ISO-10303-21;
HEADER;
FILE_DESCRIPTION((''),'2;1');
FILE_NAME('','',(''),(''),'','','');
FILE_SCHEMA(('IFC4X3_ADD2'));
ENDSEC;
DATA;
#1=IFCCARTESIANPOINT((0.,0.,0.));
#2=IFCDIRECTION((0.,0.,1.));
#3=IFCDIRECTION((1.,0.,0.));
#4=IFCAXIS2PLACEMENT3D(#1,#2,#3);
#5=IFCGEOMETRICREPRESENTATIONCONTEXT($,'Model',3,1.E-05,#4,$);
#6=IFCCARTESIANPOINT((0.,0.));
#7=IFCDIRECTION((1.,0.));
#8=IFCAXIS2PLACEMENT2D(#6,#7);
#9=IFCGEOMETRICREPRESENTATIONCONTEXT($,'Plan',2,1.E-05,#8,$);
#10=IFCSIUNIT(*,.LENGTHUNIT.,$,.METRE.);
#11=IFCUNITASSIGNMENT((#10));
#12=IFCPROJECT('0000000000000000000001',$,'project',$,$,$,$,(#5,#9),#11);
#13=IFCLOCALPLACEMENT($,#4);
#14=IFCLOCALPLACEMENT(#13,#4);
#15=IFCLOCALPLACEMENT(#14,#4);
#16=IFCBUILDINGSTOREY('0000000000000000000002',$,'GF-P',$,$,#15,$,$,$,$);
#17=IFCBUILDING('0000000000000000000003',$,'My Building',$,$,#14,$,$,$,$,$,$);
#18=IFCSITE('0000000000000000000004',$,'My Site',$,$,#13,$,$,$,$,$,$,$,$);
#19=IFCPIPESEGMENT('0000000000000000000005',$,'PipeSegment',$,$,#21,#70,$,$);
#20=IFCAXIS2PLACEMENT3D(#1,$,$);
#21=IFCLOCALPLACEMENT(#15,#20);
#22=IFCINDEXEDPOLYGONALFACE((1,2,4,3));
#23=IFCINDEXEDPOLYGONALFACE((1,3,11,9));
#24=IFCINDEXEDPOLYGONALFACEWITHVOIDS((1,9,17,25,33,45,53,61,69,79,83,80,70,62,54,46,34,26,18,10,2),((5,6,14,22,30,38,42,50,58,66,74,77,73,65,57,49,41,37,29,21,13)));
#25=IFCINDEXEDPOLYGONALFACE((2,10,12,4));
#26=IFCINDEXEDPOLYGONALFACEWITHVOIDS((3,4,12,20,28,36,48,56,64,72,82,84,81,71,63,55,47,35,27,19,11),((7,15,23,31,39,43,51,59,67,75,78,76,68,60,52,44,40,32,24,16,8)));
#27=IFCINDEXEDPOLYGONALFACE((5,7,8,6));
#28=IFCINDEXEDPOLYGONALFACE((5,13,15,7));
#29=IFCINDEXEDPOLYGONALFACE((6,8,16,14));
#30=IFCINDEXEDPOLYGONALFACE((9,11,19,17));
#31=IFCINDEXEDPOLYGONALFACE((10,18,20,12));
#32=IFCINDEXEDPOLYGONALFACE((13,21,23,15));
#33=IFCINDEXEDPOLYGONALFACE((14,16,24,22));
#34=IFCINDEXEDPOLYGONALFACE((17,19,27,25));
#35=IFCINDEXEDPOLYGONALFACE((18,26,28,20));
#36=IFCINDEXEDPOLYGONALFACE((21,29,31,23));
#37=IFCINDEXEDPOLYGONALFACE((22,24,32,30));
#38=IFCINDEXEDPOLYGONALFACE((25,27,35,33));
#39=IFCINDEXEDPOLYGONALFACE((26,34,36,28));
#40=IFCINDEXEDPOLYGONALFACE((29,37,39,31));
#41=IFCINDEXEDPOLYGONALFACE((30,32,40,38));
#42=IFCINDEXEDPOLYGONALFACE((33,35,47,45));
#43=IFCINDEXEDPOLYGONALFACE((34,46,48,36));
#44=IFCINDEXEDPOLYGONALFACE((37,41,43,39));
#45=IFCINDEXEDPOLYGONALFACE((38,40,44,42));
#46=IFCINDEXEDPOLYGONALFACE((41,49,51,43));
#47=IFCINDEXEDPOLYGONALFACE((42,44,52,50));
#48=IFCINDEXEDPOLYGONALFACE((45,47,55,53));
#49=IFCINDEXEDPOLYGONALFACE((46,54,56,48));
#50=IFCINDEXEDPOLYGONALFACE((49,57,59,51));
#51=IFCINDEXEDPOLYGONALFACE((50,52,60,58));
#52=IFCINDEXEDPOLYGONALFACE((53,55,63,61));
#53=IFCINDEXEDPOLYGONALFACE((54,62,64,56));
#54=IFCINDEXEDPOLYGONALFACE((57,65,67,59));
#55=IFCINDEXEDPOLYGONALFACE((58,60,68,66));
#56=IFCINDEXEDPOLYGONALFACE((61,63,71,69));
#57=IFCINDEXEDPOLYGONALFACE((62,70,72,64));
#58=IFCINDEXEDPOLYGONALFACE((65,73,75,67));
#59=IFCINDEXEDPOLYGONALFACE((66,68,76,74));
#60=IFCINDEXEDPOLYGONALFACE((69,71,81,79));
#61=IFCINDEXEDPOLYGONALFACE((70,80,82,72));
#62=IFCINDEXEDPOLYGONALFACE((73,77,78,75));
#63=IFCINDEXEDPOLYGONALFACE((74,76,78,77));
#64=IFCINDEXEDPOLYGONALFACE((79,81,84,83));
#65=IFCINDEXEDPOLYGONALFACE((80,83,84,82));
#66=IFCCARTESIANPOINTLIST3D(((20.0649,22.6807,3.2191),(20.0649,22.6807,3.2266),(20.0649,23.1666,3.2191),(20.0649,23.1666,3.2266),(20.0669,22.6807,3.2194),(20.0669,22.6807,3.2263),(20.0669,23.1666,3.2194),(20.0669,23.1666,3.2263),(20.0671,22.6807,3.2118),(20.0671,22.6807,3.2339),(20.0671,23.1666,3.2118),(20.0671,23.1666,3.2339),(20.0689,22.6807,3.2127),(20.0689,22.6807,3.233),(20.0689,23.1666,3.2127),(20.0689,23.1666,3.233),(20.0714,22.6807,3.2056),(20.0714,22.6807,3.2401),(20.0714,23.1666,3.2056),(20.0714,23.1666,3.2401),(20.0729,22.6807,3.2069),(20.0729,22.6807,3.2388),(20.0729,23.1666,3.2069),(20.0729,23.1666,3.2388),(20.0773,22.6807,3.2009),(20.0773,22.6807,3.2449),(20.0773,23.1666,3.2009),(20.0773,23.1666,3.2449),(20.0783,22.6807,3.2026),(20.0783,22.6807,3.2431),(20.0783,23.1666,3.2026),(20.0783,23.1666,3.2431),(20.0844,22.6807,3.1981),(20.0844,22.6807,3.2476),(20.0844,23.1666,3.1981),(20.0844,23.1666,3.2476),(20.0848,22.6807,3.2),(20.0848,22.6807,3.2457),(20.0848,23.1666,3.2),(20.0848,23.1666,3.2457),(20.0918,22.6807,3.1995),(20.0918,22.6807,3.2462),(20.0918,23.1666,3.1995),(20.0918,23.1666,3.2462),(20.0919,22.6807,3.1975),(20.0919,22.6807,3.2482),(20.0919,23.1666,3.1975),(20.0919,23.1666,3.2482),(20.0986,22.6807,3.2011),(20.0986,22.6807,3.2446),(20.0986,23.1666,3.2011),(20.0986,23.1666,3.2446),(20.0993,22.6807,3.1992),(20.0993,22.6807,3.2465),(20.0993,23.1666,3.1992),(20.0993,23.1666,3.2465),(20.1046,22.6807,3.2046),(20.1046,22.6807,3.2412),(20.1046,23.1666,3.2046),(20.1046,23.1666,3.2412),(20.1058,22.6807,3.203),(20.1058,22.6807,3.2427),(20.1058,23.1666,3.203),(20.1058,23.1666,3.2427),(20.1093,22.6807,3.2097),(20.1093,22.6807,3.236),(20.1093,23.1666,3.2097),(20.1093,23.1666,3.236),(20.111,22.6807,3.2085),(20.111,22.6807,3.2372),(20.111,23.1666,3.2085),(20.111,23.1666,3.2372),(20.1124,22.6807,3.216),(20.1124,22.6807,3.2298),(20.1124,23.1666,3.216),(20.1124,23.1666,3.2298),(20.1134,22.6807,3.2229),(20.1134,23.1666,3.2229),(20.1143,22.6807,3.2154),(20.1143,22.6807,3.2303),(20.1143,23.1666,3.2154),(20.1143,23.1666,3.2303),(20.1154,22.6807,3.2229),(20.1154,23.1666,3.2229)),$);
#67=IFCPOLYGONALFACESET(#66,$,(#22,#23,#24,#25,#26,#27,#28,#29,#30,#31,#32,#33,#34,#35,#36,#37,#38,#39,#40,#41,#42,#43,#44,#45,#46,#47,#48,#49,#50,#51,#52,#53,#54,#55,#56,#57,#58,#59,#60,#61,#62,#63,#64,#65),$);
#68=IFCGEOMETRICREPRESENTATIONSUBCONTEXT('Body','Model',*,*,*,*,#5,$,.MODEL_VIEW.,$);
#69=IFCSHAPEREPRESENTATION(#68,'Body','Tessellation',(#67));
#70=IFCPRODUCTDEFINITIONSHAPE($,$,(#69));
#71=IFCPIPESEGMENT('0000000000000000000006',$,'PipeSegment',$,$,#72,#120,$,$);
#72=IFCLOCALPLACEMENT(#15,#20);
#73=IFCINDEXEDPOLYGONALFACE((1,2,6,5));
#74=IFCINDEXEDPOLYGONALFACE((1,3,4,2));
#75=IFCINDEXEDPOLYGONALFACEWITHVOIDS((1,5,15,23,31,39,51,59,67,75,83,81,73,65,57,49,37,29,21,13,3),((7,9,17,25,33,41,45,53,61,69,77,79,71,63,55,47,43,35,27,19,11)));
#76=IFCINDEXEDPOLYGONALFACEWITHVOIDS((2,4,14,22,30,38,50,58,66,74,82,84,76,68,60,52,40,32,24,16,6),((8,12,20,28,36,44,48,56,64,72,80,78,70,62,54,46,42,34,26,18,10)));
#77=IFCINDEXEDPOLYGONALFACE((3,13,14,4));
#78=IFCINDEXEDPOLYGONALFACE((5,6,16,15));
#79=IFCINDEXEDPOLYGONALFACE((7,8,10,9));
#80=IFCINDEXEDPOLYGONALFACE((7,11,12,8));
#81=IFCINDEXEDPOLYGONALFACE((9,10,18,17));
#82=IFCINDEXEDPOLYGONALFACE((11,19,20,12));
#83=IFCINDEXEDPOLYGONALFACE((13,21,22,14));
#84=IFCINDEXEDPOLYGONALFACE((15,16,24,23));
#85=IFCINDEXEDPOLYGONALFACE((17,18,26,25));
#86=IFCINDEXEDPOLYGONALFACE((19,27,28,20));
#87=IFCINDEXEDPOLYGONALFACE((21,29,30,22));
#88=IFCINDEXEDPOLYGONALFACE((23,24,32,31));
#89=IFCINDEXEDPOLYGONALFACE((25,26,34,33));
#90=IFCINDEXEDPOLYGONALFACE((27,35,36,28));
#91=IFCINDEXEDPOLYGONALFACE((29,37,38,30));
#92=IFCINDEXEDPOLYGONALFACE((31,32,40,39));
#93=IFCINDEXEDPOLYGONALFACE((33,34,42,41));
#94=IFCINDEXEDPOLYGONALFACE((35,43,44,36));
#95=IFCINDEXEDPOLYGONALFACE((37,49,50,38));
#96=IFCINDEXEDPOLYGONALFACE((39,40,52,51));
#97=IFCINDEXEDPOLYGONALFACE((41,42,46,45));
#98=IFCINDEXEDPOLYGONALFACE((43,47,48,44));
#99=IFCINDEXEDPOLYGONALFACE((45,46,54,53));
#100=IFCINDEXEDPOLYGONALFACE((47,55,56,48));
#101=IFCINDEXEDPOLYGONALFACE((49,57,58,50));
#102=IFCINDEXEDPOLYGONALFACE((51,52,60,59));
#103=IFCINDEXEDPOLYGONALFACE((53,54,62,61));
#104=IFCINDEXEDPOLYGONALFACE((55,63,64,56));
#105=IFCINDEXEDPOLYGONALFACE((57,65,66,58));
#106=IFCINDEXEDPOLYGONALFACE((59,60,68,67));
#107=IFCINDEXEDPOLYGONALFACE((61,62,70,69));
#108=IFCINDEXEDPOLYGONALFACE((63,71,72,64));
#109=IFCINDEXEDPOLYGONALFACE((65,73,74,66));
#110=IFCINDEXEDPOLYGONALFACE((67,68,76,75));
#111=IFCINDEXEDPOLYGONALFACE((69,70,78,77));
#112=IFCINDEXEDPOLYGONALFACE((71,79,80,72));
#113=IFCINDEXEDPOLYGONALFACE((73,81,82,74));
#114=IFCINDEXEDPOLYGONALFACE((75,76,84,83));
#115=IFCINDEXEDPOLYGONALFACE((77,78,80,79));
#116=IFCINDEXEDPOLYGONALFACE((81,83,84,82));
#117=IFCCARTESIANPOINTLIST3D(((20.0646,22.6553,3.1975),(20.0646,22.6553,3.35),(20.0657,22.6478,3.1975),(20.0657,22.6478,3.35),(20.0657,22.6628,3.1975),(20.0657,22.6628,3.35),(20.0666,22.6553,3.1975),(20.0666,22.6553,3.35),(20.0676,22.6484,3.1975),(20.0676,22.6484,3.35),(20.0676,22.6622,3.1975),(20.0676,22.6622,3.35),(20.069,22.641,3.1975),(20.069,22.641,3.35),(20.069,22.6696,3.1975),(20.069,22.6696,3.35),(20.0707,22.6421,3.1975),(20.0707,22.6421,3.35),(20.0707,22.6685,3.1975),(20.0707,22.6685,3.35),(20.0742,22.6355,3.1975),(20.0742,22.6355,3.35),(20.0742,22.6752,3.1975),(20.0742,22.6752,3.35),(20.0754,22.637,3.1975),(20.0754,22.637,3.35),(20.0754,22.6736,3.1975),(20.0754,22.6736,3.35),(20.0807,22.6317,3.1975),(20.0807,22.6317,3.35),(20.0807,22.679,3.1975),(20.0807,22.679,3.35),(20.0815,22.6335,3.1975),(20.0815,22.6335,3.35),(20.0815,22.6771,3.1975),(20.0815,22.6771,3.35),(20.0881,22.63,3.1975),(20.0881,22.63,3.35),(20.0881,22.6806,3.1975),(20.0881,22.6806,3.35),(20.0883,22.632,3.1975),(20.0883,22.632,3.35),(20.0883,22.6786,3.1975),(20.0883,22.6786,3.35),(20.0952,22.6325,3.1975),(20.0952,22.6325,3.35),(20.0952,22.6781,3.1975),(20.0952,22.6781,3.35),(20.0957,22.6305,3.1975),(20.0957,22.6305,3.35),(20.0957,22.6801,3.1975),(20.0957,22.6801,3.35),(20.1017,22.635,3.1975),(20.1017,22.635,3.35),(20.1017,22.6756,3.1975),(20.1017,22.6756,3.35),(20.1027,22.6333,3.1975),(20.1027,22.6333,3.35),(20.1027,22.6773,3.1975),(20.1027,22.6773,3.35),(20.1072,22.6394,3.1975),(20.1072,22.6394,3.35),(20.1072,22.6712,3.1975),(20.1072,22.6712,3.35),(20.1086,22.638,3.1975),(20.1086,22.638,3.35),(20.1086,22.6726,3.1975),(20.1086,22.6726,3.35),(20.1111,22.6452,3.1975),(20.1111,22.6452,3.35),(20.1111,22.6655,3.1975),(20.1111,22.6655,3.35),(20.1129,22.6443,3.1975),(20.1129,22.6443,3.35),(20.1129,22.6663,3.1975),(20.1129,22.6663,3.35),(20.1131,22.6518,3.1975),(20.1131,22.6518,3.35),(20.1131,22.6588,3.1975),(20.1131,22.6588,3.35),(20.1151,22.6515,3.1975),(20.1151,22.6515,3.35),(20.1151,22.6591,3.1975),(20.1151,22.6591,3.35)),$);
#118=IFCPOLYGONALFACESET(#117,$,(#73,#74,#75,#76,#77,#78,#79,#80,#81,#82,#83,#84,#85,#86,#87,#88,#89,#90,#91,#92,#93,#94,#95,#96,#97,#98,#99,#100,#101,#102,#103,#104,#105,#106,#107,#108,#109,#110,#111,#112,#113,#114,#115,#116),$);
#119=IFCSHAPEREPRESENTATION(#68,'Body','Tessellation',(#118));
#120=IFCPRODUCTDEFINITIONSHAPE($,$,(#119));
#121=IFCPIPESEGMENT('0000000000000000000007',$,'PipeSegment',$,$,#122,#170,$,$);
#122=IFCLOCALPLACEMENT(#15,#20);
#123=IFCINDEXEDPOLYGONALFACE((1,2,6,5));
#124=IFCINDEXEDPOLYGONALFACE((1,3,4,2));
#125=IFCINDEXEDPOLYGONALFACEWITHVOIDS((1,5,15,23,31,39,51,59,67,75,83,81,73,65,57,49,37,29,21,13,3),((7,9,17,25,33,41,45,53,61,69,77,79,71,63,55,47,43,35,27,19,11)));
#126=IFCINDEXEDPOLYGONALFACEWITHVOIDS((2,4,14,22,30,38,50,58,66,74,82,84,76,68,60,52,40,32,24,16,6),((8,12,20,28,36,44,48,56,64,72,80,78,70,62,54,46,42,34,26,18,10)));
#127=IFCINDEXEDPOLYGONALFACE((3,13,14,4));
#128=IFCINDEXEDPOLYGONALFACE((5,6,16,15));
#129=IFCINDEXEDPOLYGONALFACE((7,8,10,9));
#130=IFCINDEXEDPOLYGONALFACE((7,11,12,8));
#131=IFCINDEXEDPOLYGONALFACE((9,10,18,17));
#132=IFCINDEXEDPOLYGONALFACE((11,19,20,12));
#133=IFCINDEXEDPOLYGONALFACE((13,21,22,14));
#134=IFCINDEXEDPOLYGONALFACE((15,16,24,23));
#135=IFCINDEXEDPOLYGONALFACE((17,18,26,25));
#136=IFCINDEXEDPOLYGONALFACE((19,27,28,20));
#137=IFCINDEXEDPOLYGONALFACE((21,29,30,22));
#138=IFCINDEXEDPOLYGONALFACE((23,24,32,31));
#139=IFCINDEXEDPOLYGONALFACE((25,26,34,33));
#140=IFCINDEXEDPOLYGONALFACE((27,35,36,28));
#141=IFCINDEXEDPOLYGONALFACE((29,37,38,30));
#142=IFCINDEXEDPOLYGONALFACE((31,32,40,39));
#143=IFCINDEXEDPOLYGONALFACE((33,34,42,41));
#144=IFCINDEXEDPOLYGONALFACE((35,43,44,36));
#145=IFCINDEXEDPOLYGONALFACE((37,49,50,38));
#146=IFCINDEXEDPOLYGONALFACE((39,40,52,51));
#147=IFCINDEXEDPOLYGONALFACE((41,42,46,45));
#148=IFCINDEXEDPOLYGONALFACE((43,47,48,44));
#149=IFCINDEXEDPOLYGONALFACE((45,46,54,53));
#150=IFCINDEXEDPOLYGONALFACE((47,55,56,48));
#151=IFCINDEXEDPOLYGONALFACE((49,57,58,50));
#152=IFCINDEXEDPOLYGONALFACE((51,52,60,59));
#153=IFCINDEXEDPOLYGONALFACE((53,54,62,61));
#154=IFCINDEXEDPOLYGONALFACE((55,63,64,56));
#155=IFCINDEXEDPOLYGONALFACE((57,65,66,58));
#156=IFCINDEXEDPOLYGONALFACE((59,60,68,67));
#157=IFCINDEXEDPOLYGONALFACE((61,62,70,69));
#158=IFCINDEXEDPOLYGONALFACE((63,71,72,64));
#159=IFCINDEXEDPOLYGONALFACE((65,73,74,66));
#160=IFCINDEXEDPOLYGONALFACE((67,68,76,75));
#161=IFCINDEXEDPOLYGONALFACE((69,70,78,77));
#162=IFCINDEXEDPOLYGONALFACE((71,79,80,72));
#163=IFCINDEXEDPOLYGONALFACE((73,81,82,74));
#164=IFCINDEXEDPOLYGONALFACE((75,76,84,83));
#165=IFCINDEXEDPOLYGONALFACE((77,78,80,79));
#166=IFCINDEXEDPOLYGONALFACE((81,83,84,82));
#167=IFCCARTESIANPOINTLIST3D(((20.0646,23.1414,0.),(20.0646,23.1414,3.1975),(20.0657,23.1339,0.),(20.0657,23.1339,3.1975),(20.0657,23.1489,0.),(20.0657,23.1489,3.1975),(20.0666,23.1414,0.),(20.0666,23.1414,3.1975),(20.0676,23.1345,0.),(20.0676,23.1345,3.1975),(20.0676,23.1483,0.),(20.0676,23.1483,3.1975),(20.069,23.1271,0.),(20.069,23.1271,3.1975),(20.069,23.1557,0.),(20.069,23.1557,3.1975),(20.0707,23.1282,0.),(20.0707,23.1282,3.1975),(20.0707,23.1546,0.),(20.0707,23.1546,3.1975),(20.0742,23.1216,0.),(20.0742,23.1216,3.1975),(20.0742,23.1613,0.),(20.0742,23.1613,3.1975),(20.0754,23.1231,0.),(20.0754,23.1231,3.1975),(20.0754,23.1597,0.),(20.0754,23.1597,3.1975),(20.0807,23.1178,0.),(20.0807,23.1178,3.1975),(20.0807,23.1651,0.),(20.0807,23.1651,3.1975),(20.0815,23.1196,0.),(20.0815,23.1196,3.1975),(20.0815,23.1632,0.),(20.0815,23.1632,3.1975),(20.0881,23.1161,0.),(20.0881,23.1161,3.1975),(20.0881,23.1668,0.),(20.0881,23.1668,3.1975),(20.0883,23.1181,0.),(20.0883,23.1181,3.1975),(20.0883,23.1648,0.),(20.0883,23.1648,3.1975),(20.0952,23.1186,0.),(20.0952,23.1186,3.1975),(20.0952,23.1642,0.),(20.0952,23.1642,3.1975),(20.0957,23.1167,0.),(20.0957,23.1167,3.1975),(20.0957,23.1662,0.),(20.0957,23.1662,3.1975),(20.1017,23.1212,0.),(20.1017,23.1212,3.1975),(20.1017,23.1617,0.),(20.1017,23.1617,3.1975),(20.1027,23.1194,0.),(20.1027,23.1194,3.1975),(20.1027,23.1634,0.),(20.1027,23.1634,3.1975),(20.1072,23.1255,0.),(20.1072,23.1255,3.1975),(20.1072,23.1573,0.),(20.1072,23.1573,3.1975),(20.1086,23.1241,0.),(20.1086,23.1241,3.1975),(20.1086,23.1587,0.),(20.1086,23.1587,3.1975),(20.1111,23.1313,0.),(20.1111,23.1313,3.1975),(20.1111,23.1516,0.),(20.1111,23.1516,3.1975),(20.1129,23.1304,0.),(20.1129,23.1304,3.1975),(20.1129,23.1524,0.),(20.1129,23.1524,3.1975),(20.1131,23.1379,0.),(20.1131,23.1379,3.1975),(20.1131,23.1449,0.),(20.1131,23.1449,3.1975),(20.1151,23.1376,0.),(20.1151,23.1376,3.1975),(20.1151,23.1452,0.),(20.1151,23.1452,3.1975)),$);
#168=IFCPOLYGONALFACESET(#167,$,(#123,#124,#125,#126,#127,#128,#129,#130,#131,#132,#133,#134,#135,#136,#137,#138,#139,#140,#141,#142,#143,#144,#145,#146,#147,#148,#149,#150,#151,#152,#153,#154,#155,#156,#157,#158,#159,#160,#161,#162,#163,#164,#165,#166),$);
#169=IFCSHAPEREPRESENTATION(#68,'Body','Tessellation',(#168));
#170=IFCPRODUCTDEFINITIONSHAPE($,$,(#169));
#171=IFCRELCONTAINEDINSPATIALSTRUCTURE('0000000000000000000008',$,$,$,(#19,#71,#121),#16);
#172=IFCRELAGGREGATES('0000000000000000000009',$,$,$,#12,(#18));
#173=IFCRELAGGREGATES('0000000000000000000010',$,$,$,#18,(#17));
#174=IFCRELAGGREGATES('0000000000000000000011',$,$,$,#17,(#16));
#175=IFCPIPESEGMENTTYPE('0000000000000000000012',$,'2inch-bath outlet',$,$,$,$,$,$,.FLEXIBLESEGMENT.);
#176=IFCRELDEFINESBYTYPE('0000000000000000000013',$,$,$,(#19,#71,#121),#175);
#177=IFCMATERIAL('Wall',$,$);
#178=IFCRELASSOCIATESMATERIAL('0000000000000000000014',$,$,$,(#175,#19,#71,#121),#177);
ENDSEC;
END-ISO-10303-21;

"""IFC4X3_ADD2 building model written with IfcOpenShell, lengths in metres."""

from ifc_helpers import new_model, si_unit, frame, origin_with_axes, origin_2d_with_axis, place, context, subcontext, project, spatial, hollow_circle, extrude, material, material_profile, profile_set, profile_usage, type_object, element, save


model = new_model("IFC4X3_ADD2")

# Units and contexts
model_context = context("Model", 3, precision=1e-05, world=origin_with_axes())
plan_context = context("Plan", 2, precision=1e-05, world=origin_2d_with_axis())
body_context = subcontext(model_context, "Body", "Model", "MODEL_VIEW")
ifc_project = project(units=[si_unit("LENGTHUNIT", "METRE")], contexts=[model_context, plan_context])

# Site, building, storey
site_placement = place(None, origin_with_axes())
site = spatial("IfcSite", under=ifc_project, at=site_placement, Name="My Site")
building_placement = place(site_placement, origin_with_axes())
building = spatial("IfcBuilding", under=site, at=building_placement, Name="My Building")
storey_placement = place(building_placement, origin_with_axes())
storey = spatial("IfcBuildingStorey", under=building, at=storey_placement, Name="GF-P")

# Pipe segments
ifc_material_1 = material(Name="Wall")
ifc_material_profile_1 = material_profile(ifc_material_1, hollow_circle(Radius=0.0254, WallThickness=0.002))
ifc_profile_set_1 = profile_set([ifc_material_profile_1], Name="graywater")
pipe_segment_type_1 = type_object("IfcPipeSegmentType", Name="2inch-bath outlet", PredefinedType="FLEXIBLESEGMENT", material=ifc_profile_set_1)
ifc_profile_usage_1 = profile_usage(ifc_profile_set_1)
pipe_segment_1_placement = place(storey_placement, frame((20.09, 23.1666, 3.2229), z_axis=(0.0, -1.0, 0.0), x_axis=(1.0, 0.0, 0.0)))
element("IfcPipeSegment", 1, at=pipe_segment_1_placement, inside=storey, type_object=pipe_segment_type_1, material=ifc_profile_usage_1, Name="PipeSegment", context=body_context, shape_type="SweptSolid", body=[
    extrude(hollow_circle(Radius=0.0254, WallThickness=0.002), origin_with_axes(), (0.0, 0.0, 1.0), 0.4859),
])
ifc_profile_usage_2 = profile_usage(ifc_profile_set_1)
pipe_segment_2_placement = place(storey_placement, frame((20.09, 22.6553, 3.1975), z_axis=(0.0, 0.0, 1.0), x_axis=(-1.0, 0.0, 0.0)))
element("IfcPipeSegment", 2, at=pipe_segment_2_placement, inside=storey, type_object=pipe_segment_type_1, material=ifc_profile_usage_2, Name="PipeSegment", context=body_context, shape_type="SweptSolid", body=[
    extrude(hollow_circle(Radius=0.0254, WallThickness=0.002), origin_with_axes(), (0.0, 0.0, 1.0), 0.1525),
])
ifc_profile_usage_3 = profile_usage(ifc_profile_set_1)
pipe_segment_3_placement = place(storey_placement, frame((20.09, 23.1414, 0.0), z_axis=(0.0, 0.0, 1.0), x_axis=(-1.0, 0.0, 0.0)))
element("IfcPipeSegment", 3, at=pipe_segment_3_placement, inside=storey, type_object=pipe_segment_type_1, material=ifc_profile_usage_3, Name="PipeSegment", context=body_context, shape_type="SweptSolid", body=[
    extrude(hollow_circle(Radius=0.0254, WallThickness=0.002), origin_with_axes(), (0.0, 0.0, 1.0), 3.1975),
])

save(model, "model.ifc")
